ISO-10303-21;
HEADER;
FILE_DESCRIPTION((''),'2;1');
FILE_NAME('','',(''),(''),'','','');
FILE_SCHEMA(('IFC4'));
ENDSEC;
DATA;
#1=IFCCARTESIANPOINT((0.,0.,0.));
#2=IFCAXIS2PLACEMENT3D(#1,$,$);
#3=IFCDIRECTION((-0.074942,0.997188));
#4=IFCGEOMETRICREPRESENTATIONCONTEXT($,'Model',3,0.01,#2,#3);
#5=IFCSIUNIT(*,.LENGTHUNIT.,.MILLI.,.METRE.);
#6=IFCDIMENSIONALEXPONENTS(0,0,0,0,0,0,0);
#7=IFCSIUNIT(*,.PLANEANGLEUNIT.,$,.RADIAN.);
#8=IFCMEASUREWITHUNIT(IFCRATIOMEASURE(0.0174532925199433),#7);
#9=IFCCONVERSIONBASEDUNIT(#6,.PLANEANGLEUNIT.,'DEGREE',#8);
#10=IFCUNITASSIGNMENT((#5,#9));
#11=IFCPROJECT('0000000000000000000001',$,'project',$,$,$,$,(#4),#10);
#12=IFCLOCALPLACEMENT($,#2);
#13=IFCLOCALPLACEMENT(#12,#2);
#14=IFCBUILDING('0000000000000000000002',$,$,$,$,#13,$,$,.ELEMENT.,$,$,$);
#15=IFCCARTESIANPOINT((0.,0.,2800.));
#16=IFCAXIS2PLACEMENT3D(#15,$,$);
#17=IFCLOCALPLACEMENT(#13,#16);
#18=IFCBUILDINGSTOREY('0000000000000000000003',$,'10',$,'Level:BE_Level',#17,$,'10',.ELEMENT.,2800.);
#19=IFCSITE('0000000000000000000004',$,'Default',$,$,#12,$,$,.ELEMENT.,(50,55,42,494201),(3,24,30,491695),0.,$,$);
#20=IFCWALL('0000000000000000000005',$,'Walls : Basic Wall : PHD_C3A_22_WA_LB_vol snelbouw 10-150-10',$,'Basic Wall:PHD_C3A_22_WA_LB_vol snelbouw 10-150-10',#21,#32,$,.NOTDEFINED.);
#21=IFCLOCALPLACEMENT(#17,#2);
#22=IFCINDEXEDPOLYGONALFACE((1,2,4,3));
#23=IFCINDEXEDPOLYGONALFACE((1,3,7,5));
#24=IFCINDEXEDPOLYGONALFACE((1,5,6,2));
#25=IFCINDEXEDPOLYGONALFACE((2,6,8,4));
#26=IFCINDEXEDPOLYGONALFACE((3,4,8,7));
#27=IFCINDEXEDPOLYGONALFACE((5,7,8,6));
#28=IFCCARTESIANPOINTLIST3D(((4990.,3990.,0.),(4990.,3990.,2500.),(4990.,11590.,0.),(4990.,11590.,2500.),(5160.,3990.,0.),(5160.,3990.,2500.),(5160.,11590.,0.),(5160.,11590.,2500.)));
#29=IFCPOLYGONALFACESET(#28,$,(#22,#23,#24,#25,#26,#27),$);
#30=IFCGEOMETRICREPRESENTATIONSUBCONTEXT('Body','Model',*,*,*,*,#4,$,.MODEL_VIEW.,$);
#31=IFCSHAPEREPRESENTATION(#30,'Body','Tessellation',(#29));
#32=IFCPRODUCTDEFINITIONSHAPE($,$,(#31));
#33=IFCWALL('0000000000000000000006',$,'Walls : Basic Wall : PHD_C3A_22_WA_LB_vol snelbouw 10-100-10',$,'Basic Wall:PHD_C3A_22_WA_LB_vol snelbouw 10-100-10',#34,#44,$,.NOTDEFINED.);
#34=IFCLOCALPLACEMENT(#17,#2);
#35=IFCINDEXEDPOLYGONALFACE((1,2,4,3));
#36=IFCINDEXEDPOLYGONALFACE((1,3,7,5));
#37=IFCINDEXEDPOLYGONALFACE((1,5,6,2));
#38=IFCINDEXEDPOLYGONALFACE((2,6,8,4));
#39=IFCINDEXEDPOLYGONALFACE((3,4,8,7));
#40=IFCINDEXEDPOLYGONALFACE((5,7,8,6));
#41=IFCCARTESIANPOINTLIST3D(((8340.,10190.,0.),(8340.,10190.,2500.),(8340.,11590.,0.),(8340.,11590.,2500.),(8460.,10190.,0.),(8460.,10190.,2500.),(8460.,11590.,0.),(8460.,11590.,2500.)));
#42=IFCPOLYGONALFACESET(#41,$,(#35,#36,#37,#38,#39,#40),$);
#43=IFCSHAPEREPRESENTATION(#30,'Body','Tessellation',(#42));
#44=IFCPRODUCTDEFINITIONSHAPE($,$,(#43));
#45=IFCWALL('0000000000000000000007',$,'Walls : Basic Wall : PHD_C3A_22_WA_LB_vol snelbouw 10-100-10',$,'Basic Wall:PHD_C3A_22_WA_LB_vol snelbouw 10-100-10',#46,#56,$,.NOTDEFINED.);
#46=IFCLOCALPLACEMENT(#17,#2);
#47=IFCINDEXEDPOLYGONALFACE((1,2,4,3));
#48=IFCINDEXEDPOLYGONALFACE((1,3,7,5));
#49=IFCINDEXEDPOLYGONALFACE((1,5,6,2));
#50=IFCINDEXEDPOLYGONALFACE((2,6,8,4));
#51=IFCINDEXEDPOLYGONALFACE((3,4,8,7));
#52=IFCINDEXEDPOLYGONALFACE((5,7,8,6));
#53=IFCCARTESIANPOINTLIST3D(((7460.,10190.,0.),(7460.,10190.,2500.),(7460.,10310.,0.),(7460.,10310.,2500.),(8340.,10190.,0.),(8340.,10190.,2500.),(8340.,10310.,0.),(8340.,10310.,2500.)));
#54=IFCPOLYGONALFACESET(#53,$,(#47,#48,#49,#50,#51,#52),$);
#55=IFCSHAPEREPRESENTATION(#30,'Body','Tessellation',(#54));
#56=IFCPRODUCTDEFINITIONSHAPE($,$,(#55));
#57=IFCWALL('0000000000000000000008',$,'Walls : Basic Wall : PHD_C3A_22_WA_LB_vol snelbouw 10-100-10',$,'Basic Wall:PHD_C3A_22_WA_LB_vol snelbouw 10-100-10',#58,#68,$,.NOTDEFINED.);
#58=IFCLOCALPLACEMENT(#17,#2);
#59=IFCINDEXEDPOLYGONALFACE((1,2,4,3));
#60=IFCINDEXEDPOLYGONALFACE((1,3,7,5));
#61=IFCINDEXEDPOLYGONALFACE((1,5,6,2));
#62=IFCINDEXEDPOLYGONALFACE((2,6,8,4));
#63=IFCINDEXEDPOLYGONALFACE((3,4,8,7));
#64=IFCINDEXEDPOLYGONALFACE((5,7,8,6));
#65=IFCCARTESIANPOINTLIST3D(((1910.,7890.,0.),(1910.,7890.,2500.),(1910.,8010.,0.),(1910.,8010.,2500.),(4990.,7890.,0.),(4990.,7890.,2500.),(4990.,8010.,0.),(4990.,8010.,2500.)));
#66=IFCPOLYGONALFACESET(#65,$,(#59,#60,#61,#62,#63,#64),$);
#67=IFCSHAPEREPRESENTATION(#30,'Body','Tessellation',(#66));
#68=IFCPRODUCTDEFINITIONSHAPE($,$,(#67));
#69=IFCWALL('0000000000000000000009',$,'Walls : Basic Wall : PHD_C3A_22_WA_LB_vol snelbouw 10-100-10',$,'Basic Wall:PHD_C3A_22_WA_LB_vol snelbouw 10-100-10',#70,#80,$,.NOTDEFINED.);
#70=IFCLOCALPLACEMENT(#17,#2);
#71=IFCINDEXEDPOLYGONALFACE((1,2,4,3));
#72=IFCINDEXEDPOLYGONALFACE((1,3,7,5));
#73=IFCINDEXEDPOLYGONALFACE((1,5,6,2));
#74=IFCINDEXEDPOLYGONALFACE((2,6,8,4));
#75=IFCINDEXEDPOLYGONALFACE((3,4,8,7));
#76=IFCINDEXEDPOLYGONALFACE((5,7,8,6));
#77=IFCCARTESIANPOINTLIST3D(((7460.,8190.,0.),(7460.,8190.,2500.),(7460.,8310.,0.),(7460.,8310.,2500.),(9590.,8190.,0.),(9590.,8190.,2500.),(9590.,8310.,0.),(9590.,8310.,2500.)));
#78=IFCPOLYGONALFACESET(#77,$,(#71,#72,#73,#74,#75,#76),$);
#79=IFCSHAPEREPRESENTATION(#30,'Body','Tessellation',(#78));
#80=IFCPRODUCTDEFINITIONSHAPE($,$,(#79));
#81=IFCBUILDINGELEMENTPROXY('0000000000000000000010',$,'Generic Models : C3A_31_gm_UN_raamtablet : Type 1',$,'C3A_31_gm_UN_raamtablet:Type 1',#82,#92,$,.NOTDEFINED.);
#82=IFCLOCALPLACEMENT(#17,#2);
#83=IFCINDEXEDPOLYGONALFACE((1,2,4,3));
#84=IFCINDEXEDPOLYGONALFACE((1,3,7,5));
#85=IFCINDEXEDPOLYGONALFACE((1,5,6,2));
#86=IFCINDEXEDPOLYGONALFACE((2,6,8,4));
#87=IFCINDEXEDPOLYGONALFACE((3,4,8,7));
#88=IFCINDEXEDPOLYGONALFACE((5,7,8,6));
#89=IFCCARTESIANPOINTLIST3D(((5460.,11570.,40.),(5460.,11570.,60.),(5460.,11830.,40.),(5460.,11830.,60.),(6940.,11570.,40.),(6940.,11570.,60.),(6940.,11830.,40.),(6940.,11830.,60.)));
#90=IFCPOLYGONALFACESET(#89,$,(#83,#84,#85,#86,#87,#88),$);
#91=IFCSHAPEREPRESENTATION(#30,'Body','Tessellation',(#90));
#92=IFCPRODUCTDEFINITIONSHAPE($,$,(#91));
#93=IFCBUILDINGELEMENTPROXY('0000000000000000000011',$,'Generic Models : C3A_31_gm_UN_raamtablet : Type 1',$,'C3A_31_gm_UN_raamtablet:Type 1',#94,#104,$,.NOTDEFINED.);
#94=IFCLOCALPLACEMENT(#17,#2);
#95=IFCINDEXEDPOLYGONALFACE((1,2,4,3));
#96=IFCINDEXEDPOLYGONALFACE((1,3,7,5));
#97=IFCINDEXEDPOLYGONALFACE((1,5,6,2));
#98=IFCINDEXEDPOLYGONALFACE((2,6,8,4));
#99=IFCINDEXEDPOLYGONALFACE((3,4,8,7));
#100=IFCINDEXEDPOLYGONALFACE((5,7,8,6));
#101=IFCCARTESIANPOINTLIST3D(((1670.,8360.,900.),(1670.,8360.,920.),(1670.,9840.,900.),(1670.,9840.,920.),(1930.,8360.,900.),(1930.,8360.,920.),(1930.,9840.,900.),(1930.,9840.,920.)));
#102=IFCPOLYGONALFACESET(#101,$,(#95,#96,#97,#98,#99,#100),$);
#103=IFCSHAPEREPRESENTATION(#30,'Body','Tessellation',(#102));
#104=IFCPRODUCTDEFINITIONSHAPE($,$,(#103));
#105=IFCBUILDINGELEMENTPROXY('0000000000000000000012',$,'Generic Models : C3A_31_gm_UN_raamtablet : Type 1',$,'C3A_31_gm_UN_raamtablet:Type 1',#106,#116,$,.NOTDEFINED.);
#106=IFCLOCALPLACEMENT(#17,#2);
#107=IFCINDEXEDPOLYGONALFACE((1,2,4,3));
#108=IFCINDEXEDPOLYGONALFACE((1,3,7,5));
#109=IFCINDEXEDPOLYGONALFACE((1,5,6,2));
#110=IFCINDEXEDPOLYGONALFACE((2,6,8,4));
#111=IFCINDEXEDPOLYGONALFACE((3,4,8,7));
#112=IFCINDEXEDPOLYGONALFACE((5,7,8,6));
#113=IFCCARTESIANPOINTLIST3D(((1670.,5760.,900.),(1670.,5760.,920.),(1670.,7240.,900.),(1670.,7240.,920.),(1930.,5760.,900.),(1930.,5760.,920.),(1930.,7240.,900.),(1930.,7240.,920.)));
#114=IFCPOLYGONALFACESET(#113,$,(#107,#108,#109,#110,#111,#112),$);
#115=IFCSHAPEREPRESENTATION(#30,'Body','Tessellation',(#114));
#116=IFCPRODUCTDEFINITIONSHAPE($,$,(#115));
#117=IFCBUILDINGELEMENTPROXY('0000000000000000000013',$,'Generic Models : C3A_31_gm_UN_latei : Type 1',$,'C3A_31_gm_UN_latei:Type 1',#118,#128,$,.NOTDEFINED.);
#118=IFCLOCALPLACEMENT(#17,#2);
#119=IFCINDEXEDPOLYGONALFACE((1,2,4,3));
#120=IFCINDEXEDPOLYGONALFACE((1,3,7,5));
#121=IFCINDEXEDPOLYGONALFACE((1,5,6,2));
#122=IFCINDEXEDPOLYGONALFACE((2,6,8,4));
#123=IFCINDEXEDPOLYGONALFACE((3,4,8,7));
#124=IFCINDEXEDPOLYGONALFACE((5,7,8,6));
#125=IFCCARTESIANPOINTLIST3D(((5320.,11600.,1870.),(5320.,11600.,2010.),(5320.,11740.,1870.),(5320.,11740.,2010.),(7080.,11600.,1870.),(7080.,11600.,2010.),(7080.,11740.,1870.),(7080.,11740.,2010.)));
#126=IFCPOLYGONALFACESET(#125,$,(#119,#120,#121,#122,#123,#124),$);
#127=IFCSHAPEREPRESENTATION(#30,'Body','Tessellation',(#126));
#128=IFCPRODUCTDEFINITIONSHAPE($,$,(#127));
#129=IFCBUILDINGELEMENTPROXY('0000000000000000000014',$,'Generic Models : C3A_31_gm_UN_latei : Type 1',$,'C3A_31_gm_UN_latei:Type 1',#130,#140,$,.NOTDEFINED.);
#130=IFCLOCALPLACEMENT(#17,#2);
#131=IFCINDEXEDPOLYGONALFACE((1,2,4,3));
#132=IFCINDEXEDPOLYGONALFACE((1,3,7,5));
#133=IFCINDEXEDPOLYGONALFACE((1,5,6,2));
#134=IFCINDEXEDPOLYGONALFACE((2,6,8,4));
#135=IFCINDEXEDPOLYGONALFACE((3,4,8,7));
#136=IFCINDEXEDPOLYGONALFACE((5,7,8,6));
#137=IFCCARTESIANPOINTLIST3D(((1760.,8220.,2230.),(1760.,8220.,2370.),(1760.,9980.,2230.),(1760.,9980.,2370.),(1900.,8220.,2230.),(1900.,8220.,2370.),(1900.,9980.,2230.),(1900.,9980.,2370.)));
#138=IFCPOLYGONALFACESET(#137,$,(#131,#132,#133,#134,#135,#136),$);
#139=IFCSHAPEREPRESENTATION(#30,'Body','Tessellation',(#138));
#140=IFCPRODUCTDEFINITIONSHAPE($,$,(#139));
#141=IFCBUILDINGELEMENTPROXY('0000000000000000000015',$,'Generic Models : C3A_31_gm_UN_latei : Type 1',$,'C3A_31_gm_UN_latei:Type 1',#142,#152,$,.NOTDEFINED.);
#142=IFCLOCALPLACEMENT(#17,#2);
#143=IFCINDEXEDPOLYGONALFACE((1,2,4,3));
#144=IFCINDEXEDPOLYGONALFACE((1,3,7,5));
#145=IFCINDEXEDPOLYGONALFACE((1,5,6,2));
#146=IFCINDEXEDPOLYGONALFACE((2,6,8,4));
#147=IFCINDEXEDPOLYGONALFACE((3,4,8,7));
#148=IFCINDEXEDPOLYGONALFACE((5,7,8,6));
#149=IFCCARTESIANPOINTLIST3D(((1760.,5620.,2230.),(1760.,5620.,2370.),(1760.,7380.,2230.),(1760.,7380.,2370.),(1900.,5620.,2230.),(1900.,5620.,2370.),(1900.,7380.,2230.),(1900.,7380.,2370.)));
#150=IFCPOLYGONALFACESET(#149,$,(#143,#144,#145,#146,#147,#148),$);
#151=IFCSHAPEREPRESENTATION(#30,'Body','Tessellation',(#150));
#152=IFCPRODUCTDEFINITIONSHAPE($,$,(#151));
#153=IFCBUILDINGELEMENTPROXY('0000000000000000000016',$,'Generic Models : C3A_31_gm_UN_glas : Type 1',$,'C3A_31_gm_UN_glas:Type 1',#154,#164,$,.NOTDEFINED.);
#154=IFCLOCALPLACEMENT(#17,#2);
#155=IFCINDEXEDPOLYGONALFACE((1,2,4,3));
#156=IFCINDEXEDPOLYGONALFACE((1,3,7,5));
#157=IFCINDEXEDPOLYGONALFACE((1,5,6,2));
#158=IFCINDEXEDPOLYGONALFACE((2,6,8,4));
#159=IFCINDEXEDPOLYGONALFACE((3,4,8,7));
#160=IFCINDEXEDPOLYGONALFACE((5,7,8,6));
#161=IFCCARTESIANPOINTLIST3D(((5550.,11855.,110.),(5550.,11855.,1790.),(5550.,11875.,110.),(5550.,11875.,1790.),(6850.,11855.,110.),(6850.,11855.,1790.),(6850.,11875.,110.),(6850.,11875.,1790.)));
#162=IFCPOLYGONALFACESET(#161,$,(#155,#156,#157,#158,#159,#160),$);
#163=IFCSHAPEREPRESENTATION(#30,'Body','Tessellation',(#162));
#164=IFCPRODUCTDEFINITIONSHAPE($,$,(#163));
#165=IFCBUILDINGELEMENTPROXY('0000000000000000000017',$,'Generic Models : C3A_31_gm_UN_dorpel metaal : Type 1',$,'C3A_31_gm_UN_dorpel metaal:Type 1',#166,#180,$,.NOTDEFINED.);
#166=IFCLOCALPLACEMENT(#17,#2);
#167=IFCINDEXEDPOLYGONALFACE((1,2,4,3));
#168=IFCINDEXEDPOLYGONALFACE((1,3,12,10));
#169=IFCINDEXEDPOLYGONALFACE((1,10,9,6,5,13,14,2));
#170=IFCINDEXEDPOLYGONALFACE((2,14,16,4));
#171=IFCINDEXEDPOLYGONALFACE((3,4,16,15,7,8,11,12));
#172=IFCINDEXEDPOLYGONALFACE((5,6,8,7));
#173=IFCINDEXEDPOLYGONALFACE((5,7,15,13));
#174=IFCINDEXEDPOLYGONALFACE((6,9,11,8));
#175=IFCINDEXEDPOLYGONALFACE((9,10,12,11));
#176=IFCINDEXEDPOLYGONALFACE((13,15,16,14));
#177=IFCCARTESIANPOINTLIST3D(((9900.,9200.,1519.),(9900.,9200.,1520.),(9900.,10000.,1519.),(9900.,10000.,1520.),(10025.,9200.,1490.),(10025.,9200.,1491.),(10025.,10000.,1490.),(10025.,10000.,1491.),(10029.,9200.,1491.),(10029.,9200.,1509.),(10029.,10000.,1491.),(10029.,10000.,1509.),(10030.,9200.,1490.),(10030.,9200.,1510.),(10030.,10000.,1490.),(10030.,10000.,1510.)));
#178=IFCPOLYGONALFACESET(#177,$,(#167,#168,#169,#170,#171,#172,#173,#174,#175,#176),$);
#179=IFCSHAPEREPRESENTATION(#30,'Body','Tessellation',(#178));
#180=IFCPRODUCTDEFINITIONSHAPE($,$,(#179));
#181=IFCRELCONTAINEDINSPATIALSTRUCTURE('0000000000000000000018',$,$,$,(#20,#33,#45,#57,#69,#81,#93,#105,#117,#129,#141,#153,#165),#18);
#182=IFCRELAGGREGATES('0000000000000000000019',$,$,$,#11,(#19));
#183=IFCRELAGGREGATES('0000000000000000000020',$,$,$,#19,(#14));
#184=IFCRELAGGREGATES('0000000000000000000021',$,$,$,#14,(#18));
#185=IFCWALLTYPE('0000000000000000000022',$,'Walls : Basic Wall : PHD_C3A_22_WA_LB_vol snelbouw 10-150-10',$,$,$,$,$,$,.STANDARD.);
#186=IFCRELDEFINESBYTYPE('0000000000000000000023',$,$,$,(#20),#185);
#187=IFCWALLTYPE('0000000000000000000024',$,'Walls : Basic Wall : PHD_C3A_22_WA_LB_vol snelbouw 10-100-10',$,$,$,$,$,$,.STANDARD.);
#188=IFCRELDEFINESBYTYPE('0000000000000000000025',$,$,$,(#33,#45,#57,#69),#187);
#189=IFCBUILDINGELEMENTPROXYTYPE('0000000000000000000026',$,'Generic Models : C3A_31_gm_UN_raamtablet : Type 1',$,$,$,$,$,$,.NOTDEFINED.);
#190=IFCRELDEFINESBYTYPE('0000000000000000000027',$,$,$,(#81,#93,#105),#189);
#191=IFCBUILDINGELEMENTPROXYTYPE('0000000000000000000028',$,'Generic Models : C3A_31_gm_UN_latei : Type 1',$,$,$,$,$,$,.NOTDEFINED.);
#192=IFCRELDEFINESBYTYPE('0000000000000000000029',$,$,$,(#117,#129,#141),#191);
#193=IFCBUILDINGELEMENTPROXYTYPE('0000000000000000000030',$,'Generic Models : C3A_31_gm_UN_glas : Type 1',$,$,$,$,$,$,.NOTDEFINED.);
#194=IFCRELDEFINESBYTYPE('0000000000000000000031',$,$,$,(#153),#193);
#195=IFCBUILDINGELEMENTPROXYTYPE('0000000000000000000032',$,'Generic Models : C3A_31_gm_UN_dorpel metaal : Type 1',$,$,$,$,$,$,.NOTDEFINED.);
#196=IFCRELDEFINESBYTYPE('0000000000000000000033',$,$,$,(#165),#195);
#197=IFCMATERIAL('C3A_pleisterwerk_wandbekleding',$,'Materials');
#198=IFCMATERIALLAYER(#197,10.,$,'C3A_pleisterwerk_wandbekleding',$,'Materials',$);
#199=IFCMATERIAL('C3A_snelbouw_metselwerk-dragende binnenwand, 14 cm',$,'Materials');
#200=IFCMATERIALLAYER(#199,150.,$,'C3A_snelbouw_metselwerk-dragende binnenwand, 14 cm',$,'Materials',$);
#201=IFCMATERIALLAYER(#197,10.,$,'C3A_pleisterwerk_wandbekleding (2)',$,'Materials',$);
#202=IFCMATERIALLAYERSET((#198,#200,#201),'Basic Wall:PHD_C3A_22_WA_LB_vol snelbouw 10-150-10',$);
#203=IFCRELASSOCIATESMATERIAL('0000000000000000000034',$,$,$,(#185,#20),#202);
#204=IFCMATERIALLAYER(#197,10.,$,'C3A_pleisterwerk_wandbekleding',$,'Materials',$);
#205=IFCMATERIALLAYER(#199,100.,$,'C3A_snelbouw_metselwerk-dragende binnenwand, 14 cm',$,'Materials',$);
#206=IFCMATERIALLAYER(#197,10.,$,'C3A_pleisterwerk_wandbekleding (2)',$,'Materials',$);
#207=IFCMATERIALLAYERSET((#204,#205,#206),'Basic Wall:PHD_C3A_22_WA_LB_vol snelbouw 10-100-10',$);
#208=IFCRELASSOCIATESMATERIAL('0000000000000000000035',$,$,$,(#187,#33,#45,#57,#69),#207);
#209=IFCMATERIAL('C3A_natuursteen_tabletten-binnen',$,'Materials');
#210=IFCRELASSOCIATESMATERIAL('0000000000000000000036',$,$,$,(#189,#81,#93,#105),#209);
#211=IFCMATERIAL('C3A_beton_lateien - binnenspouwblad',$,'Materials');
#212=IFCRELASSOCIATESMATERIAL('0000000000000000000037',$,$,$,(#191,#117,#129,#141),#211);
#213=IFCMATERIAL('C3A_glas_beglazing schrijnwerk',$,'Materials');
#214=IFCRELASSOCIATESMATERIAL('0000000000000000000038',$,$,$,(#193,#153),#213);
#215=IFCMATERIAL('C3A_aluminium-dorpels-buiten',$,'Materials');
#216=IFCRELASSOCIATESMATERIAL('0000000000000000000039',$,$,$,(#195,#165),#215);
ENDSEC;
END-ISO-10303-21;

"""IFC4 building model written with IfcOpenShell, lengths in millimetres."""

from ifc_helpers import new_model, entity, si_unit, converted_unit, direction, frame, frame_2d, origin, origin_2d_with_axis, place, context, subcontext, project, spatial, polyline, rectangle, outline, extrude, source, transform, mapped, material, layer, layer_set, layer_usage, type_object, type_shapes, element, save


model = new_model("IFC4")

# Units and contexts
model_context = context("Model", 3, precision=0.01, world=origin(), true_north=direction((-0.074942, 0.997188)))
body_context = subcontext(model_context, "Body", "Model", "MODEL_VIEW")
ifc_project = project(units=[si_unit("LENGTHUNIT", "METRE", prefix="MILLI"), converted_unit("PLANEANGLEUNIT", "DEGREE", entity("IfcRatioMeasure", 0.0174532925199433), si_unit("PLANEANGLEUNIT", "RADIAN"), dimensions=[0, 0, 0, 0, 0, 0, 0])], contexts=[model_context])

# Site, building, storey
site_placement = place(None, origin())
site = spatial("IfcSite", under=ifc_project, at=site_placement, Name="Default", CompositionType="ELEMENT", RefLatitude=(50, 55, 42, 494201), RefLongitude=(3, 24, 30, 491695), RefElevation=0.0)
building_placement = place(site_placement, origin())
building = spatial("IfcBuilding", under=site, at=building_placement, CompositionType="ELEMENT")
storey_placement = place(building_placement, frame((0.0, 0.0, 2800.0)))
storey = spatial("IfcBuildingStorey", under=building, at=storey_placement, Name="10", ObjectType="Level:BE_Level", LongName="10", CompositionType="ELEMENT", Elevation=2800.0)

# Walls
ifc_material_1 = material(Name="C3A_pleisterwerk_wandbekleding", Category="Materials")
ifc_layer_1 = layer(ifc_material_1, 10.0, Name="C3A_pleisterwerk_wandbekleding", Category="Materials")
ifc_material_2 = material(Name="C3A_snelbouw_metselwerk-dragende binnenwand, 14 cm", Category="Materials")
ifc_layer_2 = layer(ifc_material_2, 150.0, Name="C3A_snelbouw_metselwerk-dragende binnenwand, 14 cm", Category="Materials")
ifc_layer_3 = layer(ifc_material_1, 10.0, Name="C3A_pleisterwerk_wandbekleding (2)", Category="Materials")
ifc_layer_set_1 = layer_set([ifc_layer_1, ifc_layer_2, ifc_layer_3], Name="Basic Wall:PHD_C3A_22_WA_LB_vol snelbouw 10-150-10")
ifc_layer_usage_1 = layer_usage(ifc_layer_set_1, "AXIS2", "NEGATIVE", 85.0)
wall_type_1 = type_object("IfcWallType", Name="Walls : Basic Wall : PHD_C3A_22_WA_LB_vol snelbouw 10-150-10", PredefinedType="STANDARD", material=ifc_layer_set_1)
wall_1_placement = place(storey_placement, frame((5075.0, 11590.0, 0.0), z_axis=(0.0, 0.0, 1.0), x_axis=(0.0, -1.0, 0.0)))
element("IfcWall", 1, at=wall_1_placement, inside=storey, type_object=wall_type_1, material=ifc_layer_usage_1, Name="Walls : Basic Wall : PHD_C3A_22_WA_LB_vol snelbouw 10-150-10", ObjectType="Basic Wall:PHD_C3A_22_WA_LB_vol snelbouw 10-150-10", PredefinedType="NOTDEFINED", context=body_context, shape_type="SweptSolid", body=[
    extrude(rectangle(XDim=7600.0, YDim=170.0, at=frame_2d((3800.0, 0.0), x_axis=(-1.0, 0.0))), origin(), (0.0, 0.0, 1.0), 2500.0),
])
ifc_layer_4 = layer(ifc_material_1, 10.0, Name="C3A_pleisterwerk_wandbekleding", Category="Materials")
ifc_layer_5 = layer(ifc_material_2, 100.0, Name="C3A_snelbouw_metselwerk-dragende binnenwand, 14 cm", Category="Materials")
ifc_layer_6 = layer(ifc_material_1, 10.0, Name="C3A_pleisterwerk_wandbekleding (2)", Category="Materials")
ifc_layer_set_2 = layer_set([ifc_layer_4, ifc_layer_5, ifc_layer_6], Name="Basic Wall:PHD_C3A_22_WA_LB_vol snelbouw 10-100-10")
ifc_layer_usage_2 = layer_usage(ifc_layer_set_2, "AXIS2", "NEGATIVE", 60.0)
wall_type_2 = type_object("IfcWallType", Name="Walls : Basic Wall : PHD_C3A_22_WA_LB_vol snelbouw 10-100-10", PredefinedType="STANDARD", material=ifc_layer_set_2)
wall_2_placement = place(storey_placement, frame((8400.0, 11590.0, 0.0), z_axis=(0.0, 0.0, 1.0), x_axis=(0.0, -1.0, 0.0)))
element("IfcWall", 2, at=wall_2_placement, inside=storey, type_object=wall_type_2, material=ifc_layer_usage_2, Name="Walls : Basic Wall : PHD_C3A_22_WA_LB_vol snelbouw 10-100-10", ObjectType="Basic Wall:PHD_C3A_22_WA_LB_vol snelbouw 10-100-10", PredefinedType="NOTDEFINED", context=body_context, shape_type="SweptSolid", body=[
    extrude(rectangle(XDim=1400.0, YDim=120.0, at=frame_2d((700.0, 0.0), x_axis=(-1.0, 0.0))), origin(), (0.0, 0.0, 1.0), 2500.0),
])
ifc_layer_usage_3 = layer_usage(ifc_layer_set_2, "AXIS2", "NEGATIVE", 60.0)
wall_3_placement = place(storey_placement, frame((8340.0, 10250.0, 0.0), z_axis=(0.0, 0.0, 1.0), x_axis=(-1.0, 0.0, 0.0)))
element("IfcWall", 3, at=wall_3_placement, inside=storey, type_object=wall_type_2, material=ifc_layer_usage_3, Name="Walls : Basic Wall : PHD_C3A_22_WA_LB_vol snelbouw 10-100-10", ObjectType="Basic Wall:PHD_C3A_22_WA_LB_vol snelbouw 10-100-10", PredefinedType="NOTDEFINED", context=body_context, shape_type="SweptSolid", body=[
    extrude(rectangle(XDim=880.0, YDim=120.0, at=frame_2d((440.0, 0.0), x_axis=(-1.0, 0.0))), origin(), (0.0, 0.0, 1.0), 2500.0),
])
ifc_layer_usage_4 = layer_usage(ifc_layer_set_2, "AXIS2", "NEGATIVE", 60.0)
wall_4_placement = place(storey_placement, frame((1910.0, 7950.0, 0.0)))
element("IfcWall", 4, at=wall_4_placement, inside=storey, type_object=wall_type_2, material=ifc_layer_usage_4, Name="Walls : Basic Wall : PHD_C3A_22_WA_LB_vol snelbouw 10-100-10", ObjectType="Basic Wall:PHD_C3A_22_WA_LB_vol snelbouw 10-100-10", PredefinedType="NOTDEFINED", context=body_context, shape_type="SweptSolid", body=[
    extrude(rectangle(XDim=3080.0, YDim=120.0, at=frame_2d((1540.0, 0.0), x_axis=(-1.0, 0.0))), origin(), (0.0, 0.0, 1.0), 2500.0),
])
ifc_layer_usage_5 = layer_usage(ifc_layer_set_2, "AXIS2", "NEGATIVE", 60.0)
wall_5_placement = place(storey_placement, frame((7460.0, 8250.0, 0.0)))
element("IfcWall", 5, at=wall_5_placement, inside=storey, type_object=wall_type_2, material=ifc_layer_usage_5, Name="Walls : Basic Wall : PHD_C3A_22_WA_LB_vol snelbouw 10-100-10", ObjectType="Basic Wall:PHD_C3A_22_WA_LB_vol snelbouw 10-100-10", PredefinedType="NOTDEFINED", context=body_context, shape_type="SweptSolid", body=[
    extrude(rectangle(XDim=2130.0, YDim=120.0, at=frame_2d((1065.0, 0.0), x_axis=(-1.0, 0.0))), origin(), (0.0, 0.0, 1.0), 2500.0),
])

# Building element proxies
ifc_material_3 = material(Name="C3A_natuursteen_tabletten-binnen", Category="Materials")
building_element_proxy_type_1 = type_object("IfcBuildingElementProxyType", Name="Generic Models : C3A_31_gm_UN_raamtablet : Type 1", PredefinedType="NOTDEFINED", material=ifc_material_3)
shared_shape_1 = source(origin(), body_context, "Body", "SweptSolid", [
    extrude(rectangle(XDim=1480.0, YDim=260.0, at=origin_2d_with_axis()), frame((0.0, 130.0, 0.0), z_axis=(0.0, 0.0, 1.0), x_axis=(-1.0, 0.0, 0.0)), (0.0, 0.0, 1.0), 20.0),
])
type_shapes(building_element_proxy_type_1, [shared_shape_1])
proxy_1_placement = place(storey_placement, frame((6200.0, 11570.0, 40.0)))
element("IfcBuildingElementProxy", 6, at=proxy_1_placement, inside=storey, type_object=building_element_proxy_type_1, material=ifc_material_3, Name="Generic Models : C3A_31_gm_UN_raamtablet : Type 1", ObjectType="C3A_31_gm_UN_raamtablet:Type 1", PredefinedType="NOTDEFINED", context=body_context, shape_type="MappedRepresentation", body=[
    mapped(shared_shape_1, transform((0.0, 0.0, 0.0), scale=1.0)),
])
for number, where, z_axis, x_axis, name in (
    (7, (1930.0, 9100.0, 900.0), (0.0, 0.0, 1.0), (0.0, 1.0, 0.0), "Generic Models : C3A_31_gm_UN_raamtablet : Type 1"),
    (8, (1930.0, 6500.0, 900.0), (0.0, 0.0, 1.0), (0.0, 1.0, 0.0), "Generic Models : C3A_31_gm_UN_raamtablet : Type 1"),
):
    element("IfcBuildingElementProxy", number, at=place(storey_placement, frame(where, z_axis=z_axis, x_axis=x_axis)), inside=storey, type_object=building_element_proxy_type_1, material=ifc_material_3, Name=name, ObjectType="C3A_31_gm_UN_raamtablet:Type 1", PredefinedType="NOTDEFINED", context=body_context, shape_type="MappedRepresentation", body=[
        mapped(shared_shape_1, transform((0.0, 0.0, 0.0), scale=1.0)),
    ])
ifc_material_4 = material(Name="C3A_beton_lateien - binnenspouwblad", Category="Materials")
building_element_proxy_type_2 = type_object("IfcBuildingElementProxyType", Name="Generic Models : C3A_31_gm_UN_latei : Type 1", PredefinedType="NOTDEFINED", material=ifc_material_4)
shared_shape_2 = source(origin(), body_context, "Body", "SweptSolid", [
    extrude(rectangle(XDim=1760.0, YDim=140.0, at=origin_2d_with_axis()), frame((0.0, 70.0, 0.0), z_axis=(0.0, 0.0, 1.0), x_axis=(-1.0, 0.0, 0.0)), (0.0, 0.0, 1.0), 140.0),
])
type_shapes(building_element_proxy_type_2, [shared_shape_2])
proxy_2_placement = place(storey_placement, frame((6200.0, 11600.0, 1870.0)))
element("IfcBuildingElementProxy", 9, at=proxy_2_placement, inside=storey, type_object=building_element_proxy_type_2, material=ifc_material_4, Name="Generic Models : C3A_31_gm_UN_latei : Type 1", ObjectType="C3A_31_gm_UN_latei:Type 1", PredefinedType="NOTDEFINED", context=body_context, shape_type="MappedRepresentation", body=[
    mapped(shared_shape_2, transform((0.0, 0.0, 0.0), scale=1.0)),
])
for number, where, z_axis, x_axis, name in (
    (10, (1900.0, 9100.0, 2230.0), (0.0, 0.0, 1.0), (0.0, 1.0, 0.0), "Generic Models : C3A_31_gm_UN_latei : Type 1"),
    (11, (1900.0, 6500.0, 2230.0), (0.0, 0.0, 1.0), (0.0, 1.0, 0.0), "Generic Models : C3A_31_gm_UN_latei : Type 1"),
):
    element("IfcBuildingElementProxy", number, at=place(storey_placement, frame(where, z_axis=z_axis, x_axis=x_axis)), inside=storey, type_object=building_element_proxy_type_2, material=ifc_material_4, Name=name, ObjectType="C3A_31_gm_UN_latei:Type 1", PredefinedType="NOTDEFINED", context=body_context, shape_type="MappedRepresentation", body=[
        mapped(shared_shape_2, transform((0.0, 0.0, 0.0), scale=1.0)),
    ])
ifc_material_5 = material(Name="C3A_glas_beglazing schrijnwerk", Category="Materials")
building_element_proxy_type_3 = type_object("IfcBuildingElementProxyType", Name="Generic Models : C3A_31_gm_UN_glas : Type 1", PredefinedType="NOTDEFINED", material=ifc_material_5)
shared_shape_3 = source(origin(), body_context, "Body", "SweptSolid", [
    extrude(rectangle(XDim=1300.0, YDim=20.0, at=origin_2d_with_axis()), frame((650.0, 10.0, 0.0), z_axis=(0.0, 0.0, 1.0), x_axis=(-1.0, 0.0, 0.0)), (0.0, 0.0, 1.0), 1680.0),
])
type_shapes(building_element_proxy_type_3, [shared_shape_3])
proxy_3_placement = place(storey_placement, frame((5550.0, 11855.0, 110.0)))
element("IfcBuildingElementProxy", 12, at=proxy_3_placement, inside=storey, type_object=building_element_proxy_type_3, material=ifc_material_5, Name="Generic Models : C3A_31_gm_UN_glas : Type 1", ObjectType="C3A_31_gm_UN_glas:Type 1", PredefinedType="NOTDEFINED", context=body_context, shape_type="MappedRepresentation", body=[
    mapped(shared_shape_3, transform((0.0, 0.0, 0.0), scale=1.0)),
])
ifc_material_6 = material(Name="C3A_aluminium-dorpels-buiten", Category="Materials")
building_element_proxy_type_4 = type_object("IfcBuildingElementProxyType", Name="Generic Models : C3A_31_gm_UN_dorpel metaal : Type 1", PredefinedType="NOTDEFINED", material=ifc_material_6)
shared_shape_4 = source(origin(), body_context, "Body", "SweptSolid", [
    extrude(outline(polyline([(-33.3, -10.1), (97.1, -10.1), (97.0, -9.1), (-32.4, -9.1), (-33.8, 8.9), (-29.8, 9.2), (-29.9, 10.2), (-34.9, 9.9), (-33.3, -10.1)])), frame((-400.0, 96.0, 2.5), z_axis=(1.0, 0.0, 0.0), x_axis=(0.0, -0.997054, 0.076696)), (0.0, 0.0, 1.0), 800.0),
])
type_shapes(building_element_proxy_type_4, [shared_shape_4])
for number, where, z_axis, x_axis, name in (
    (13, (9900.0, 9600.0, 1500.0), (0.0, 0.0, 1.0), (0.0, -1.0, 0.0), "Generic Models : C3A_31_gm_UN_dorpel metaal : Type 1"),
):
    element("IfcBuildingElementProxy", number, at=place(storey_placement, frame(where, z_axis=z_axis, x_axis=x_axis)), inside=storey, type_object=building_element_proxy_type_4, material=ifc_material_6, Name=name, ObjectType="C3A_31_gm_UN_dorpel metaal:Type 1", PredefinedType="NOTDEFINED", context=body_context, shape_type="MappedRepresentation", body=[
        mapped(shared_shape_4, transform((0.0, 0.0, 0.0), scale=1.0)),
    ])

save(model, "model.ifc")
